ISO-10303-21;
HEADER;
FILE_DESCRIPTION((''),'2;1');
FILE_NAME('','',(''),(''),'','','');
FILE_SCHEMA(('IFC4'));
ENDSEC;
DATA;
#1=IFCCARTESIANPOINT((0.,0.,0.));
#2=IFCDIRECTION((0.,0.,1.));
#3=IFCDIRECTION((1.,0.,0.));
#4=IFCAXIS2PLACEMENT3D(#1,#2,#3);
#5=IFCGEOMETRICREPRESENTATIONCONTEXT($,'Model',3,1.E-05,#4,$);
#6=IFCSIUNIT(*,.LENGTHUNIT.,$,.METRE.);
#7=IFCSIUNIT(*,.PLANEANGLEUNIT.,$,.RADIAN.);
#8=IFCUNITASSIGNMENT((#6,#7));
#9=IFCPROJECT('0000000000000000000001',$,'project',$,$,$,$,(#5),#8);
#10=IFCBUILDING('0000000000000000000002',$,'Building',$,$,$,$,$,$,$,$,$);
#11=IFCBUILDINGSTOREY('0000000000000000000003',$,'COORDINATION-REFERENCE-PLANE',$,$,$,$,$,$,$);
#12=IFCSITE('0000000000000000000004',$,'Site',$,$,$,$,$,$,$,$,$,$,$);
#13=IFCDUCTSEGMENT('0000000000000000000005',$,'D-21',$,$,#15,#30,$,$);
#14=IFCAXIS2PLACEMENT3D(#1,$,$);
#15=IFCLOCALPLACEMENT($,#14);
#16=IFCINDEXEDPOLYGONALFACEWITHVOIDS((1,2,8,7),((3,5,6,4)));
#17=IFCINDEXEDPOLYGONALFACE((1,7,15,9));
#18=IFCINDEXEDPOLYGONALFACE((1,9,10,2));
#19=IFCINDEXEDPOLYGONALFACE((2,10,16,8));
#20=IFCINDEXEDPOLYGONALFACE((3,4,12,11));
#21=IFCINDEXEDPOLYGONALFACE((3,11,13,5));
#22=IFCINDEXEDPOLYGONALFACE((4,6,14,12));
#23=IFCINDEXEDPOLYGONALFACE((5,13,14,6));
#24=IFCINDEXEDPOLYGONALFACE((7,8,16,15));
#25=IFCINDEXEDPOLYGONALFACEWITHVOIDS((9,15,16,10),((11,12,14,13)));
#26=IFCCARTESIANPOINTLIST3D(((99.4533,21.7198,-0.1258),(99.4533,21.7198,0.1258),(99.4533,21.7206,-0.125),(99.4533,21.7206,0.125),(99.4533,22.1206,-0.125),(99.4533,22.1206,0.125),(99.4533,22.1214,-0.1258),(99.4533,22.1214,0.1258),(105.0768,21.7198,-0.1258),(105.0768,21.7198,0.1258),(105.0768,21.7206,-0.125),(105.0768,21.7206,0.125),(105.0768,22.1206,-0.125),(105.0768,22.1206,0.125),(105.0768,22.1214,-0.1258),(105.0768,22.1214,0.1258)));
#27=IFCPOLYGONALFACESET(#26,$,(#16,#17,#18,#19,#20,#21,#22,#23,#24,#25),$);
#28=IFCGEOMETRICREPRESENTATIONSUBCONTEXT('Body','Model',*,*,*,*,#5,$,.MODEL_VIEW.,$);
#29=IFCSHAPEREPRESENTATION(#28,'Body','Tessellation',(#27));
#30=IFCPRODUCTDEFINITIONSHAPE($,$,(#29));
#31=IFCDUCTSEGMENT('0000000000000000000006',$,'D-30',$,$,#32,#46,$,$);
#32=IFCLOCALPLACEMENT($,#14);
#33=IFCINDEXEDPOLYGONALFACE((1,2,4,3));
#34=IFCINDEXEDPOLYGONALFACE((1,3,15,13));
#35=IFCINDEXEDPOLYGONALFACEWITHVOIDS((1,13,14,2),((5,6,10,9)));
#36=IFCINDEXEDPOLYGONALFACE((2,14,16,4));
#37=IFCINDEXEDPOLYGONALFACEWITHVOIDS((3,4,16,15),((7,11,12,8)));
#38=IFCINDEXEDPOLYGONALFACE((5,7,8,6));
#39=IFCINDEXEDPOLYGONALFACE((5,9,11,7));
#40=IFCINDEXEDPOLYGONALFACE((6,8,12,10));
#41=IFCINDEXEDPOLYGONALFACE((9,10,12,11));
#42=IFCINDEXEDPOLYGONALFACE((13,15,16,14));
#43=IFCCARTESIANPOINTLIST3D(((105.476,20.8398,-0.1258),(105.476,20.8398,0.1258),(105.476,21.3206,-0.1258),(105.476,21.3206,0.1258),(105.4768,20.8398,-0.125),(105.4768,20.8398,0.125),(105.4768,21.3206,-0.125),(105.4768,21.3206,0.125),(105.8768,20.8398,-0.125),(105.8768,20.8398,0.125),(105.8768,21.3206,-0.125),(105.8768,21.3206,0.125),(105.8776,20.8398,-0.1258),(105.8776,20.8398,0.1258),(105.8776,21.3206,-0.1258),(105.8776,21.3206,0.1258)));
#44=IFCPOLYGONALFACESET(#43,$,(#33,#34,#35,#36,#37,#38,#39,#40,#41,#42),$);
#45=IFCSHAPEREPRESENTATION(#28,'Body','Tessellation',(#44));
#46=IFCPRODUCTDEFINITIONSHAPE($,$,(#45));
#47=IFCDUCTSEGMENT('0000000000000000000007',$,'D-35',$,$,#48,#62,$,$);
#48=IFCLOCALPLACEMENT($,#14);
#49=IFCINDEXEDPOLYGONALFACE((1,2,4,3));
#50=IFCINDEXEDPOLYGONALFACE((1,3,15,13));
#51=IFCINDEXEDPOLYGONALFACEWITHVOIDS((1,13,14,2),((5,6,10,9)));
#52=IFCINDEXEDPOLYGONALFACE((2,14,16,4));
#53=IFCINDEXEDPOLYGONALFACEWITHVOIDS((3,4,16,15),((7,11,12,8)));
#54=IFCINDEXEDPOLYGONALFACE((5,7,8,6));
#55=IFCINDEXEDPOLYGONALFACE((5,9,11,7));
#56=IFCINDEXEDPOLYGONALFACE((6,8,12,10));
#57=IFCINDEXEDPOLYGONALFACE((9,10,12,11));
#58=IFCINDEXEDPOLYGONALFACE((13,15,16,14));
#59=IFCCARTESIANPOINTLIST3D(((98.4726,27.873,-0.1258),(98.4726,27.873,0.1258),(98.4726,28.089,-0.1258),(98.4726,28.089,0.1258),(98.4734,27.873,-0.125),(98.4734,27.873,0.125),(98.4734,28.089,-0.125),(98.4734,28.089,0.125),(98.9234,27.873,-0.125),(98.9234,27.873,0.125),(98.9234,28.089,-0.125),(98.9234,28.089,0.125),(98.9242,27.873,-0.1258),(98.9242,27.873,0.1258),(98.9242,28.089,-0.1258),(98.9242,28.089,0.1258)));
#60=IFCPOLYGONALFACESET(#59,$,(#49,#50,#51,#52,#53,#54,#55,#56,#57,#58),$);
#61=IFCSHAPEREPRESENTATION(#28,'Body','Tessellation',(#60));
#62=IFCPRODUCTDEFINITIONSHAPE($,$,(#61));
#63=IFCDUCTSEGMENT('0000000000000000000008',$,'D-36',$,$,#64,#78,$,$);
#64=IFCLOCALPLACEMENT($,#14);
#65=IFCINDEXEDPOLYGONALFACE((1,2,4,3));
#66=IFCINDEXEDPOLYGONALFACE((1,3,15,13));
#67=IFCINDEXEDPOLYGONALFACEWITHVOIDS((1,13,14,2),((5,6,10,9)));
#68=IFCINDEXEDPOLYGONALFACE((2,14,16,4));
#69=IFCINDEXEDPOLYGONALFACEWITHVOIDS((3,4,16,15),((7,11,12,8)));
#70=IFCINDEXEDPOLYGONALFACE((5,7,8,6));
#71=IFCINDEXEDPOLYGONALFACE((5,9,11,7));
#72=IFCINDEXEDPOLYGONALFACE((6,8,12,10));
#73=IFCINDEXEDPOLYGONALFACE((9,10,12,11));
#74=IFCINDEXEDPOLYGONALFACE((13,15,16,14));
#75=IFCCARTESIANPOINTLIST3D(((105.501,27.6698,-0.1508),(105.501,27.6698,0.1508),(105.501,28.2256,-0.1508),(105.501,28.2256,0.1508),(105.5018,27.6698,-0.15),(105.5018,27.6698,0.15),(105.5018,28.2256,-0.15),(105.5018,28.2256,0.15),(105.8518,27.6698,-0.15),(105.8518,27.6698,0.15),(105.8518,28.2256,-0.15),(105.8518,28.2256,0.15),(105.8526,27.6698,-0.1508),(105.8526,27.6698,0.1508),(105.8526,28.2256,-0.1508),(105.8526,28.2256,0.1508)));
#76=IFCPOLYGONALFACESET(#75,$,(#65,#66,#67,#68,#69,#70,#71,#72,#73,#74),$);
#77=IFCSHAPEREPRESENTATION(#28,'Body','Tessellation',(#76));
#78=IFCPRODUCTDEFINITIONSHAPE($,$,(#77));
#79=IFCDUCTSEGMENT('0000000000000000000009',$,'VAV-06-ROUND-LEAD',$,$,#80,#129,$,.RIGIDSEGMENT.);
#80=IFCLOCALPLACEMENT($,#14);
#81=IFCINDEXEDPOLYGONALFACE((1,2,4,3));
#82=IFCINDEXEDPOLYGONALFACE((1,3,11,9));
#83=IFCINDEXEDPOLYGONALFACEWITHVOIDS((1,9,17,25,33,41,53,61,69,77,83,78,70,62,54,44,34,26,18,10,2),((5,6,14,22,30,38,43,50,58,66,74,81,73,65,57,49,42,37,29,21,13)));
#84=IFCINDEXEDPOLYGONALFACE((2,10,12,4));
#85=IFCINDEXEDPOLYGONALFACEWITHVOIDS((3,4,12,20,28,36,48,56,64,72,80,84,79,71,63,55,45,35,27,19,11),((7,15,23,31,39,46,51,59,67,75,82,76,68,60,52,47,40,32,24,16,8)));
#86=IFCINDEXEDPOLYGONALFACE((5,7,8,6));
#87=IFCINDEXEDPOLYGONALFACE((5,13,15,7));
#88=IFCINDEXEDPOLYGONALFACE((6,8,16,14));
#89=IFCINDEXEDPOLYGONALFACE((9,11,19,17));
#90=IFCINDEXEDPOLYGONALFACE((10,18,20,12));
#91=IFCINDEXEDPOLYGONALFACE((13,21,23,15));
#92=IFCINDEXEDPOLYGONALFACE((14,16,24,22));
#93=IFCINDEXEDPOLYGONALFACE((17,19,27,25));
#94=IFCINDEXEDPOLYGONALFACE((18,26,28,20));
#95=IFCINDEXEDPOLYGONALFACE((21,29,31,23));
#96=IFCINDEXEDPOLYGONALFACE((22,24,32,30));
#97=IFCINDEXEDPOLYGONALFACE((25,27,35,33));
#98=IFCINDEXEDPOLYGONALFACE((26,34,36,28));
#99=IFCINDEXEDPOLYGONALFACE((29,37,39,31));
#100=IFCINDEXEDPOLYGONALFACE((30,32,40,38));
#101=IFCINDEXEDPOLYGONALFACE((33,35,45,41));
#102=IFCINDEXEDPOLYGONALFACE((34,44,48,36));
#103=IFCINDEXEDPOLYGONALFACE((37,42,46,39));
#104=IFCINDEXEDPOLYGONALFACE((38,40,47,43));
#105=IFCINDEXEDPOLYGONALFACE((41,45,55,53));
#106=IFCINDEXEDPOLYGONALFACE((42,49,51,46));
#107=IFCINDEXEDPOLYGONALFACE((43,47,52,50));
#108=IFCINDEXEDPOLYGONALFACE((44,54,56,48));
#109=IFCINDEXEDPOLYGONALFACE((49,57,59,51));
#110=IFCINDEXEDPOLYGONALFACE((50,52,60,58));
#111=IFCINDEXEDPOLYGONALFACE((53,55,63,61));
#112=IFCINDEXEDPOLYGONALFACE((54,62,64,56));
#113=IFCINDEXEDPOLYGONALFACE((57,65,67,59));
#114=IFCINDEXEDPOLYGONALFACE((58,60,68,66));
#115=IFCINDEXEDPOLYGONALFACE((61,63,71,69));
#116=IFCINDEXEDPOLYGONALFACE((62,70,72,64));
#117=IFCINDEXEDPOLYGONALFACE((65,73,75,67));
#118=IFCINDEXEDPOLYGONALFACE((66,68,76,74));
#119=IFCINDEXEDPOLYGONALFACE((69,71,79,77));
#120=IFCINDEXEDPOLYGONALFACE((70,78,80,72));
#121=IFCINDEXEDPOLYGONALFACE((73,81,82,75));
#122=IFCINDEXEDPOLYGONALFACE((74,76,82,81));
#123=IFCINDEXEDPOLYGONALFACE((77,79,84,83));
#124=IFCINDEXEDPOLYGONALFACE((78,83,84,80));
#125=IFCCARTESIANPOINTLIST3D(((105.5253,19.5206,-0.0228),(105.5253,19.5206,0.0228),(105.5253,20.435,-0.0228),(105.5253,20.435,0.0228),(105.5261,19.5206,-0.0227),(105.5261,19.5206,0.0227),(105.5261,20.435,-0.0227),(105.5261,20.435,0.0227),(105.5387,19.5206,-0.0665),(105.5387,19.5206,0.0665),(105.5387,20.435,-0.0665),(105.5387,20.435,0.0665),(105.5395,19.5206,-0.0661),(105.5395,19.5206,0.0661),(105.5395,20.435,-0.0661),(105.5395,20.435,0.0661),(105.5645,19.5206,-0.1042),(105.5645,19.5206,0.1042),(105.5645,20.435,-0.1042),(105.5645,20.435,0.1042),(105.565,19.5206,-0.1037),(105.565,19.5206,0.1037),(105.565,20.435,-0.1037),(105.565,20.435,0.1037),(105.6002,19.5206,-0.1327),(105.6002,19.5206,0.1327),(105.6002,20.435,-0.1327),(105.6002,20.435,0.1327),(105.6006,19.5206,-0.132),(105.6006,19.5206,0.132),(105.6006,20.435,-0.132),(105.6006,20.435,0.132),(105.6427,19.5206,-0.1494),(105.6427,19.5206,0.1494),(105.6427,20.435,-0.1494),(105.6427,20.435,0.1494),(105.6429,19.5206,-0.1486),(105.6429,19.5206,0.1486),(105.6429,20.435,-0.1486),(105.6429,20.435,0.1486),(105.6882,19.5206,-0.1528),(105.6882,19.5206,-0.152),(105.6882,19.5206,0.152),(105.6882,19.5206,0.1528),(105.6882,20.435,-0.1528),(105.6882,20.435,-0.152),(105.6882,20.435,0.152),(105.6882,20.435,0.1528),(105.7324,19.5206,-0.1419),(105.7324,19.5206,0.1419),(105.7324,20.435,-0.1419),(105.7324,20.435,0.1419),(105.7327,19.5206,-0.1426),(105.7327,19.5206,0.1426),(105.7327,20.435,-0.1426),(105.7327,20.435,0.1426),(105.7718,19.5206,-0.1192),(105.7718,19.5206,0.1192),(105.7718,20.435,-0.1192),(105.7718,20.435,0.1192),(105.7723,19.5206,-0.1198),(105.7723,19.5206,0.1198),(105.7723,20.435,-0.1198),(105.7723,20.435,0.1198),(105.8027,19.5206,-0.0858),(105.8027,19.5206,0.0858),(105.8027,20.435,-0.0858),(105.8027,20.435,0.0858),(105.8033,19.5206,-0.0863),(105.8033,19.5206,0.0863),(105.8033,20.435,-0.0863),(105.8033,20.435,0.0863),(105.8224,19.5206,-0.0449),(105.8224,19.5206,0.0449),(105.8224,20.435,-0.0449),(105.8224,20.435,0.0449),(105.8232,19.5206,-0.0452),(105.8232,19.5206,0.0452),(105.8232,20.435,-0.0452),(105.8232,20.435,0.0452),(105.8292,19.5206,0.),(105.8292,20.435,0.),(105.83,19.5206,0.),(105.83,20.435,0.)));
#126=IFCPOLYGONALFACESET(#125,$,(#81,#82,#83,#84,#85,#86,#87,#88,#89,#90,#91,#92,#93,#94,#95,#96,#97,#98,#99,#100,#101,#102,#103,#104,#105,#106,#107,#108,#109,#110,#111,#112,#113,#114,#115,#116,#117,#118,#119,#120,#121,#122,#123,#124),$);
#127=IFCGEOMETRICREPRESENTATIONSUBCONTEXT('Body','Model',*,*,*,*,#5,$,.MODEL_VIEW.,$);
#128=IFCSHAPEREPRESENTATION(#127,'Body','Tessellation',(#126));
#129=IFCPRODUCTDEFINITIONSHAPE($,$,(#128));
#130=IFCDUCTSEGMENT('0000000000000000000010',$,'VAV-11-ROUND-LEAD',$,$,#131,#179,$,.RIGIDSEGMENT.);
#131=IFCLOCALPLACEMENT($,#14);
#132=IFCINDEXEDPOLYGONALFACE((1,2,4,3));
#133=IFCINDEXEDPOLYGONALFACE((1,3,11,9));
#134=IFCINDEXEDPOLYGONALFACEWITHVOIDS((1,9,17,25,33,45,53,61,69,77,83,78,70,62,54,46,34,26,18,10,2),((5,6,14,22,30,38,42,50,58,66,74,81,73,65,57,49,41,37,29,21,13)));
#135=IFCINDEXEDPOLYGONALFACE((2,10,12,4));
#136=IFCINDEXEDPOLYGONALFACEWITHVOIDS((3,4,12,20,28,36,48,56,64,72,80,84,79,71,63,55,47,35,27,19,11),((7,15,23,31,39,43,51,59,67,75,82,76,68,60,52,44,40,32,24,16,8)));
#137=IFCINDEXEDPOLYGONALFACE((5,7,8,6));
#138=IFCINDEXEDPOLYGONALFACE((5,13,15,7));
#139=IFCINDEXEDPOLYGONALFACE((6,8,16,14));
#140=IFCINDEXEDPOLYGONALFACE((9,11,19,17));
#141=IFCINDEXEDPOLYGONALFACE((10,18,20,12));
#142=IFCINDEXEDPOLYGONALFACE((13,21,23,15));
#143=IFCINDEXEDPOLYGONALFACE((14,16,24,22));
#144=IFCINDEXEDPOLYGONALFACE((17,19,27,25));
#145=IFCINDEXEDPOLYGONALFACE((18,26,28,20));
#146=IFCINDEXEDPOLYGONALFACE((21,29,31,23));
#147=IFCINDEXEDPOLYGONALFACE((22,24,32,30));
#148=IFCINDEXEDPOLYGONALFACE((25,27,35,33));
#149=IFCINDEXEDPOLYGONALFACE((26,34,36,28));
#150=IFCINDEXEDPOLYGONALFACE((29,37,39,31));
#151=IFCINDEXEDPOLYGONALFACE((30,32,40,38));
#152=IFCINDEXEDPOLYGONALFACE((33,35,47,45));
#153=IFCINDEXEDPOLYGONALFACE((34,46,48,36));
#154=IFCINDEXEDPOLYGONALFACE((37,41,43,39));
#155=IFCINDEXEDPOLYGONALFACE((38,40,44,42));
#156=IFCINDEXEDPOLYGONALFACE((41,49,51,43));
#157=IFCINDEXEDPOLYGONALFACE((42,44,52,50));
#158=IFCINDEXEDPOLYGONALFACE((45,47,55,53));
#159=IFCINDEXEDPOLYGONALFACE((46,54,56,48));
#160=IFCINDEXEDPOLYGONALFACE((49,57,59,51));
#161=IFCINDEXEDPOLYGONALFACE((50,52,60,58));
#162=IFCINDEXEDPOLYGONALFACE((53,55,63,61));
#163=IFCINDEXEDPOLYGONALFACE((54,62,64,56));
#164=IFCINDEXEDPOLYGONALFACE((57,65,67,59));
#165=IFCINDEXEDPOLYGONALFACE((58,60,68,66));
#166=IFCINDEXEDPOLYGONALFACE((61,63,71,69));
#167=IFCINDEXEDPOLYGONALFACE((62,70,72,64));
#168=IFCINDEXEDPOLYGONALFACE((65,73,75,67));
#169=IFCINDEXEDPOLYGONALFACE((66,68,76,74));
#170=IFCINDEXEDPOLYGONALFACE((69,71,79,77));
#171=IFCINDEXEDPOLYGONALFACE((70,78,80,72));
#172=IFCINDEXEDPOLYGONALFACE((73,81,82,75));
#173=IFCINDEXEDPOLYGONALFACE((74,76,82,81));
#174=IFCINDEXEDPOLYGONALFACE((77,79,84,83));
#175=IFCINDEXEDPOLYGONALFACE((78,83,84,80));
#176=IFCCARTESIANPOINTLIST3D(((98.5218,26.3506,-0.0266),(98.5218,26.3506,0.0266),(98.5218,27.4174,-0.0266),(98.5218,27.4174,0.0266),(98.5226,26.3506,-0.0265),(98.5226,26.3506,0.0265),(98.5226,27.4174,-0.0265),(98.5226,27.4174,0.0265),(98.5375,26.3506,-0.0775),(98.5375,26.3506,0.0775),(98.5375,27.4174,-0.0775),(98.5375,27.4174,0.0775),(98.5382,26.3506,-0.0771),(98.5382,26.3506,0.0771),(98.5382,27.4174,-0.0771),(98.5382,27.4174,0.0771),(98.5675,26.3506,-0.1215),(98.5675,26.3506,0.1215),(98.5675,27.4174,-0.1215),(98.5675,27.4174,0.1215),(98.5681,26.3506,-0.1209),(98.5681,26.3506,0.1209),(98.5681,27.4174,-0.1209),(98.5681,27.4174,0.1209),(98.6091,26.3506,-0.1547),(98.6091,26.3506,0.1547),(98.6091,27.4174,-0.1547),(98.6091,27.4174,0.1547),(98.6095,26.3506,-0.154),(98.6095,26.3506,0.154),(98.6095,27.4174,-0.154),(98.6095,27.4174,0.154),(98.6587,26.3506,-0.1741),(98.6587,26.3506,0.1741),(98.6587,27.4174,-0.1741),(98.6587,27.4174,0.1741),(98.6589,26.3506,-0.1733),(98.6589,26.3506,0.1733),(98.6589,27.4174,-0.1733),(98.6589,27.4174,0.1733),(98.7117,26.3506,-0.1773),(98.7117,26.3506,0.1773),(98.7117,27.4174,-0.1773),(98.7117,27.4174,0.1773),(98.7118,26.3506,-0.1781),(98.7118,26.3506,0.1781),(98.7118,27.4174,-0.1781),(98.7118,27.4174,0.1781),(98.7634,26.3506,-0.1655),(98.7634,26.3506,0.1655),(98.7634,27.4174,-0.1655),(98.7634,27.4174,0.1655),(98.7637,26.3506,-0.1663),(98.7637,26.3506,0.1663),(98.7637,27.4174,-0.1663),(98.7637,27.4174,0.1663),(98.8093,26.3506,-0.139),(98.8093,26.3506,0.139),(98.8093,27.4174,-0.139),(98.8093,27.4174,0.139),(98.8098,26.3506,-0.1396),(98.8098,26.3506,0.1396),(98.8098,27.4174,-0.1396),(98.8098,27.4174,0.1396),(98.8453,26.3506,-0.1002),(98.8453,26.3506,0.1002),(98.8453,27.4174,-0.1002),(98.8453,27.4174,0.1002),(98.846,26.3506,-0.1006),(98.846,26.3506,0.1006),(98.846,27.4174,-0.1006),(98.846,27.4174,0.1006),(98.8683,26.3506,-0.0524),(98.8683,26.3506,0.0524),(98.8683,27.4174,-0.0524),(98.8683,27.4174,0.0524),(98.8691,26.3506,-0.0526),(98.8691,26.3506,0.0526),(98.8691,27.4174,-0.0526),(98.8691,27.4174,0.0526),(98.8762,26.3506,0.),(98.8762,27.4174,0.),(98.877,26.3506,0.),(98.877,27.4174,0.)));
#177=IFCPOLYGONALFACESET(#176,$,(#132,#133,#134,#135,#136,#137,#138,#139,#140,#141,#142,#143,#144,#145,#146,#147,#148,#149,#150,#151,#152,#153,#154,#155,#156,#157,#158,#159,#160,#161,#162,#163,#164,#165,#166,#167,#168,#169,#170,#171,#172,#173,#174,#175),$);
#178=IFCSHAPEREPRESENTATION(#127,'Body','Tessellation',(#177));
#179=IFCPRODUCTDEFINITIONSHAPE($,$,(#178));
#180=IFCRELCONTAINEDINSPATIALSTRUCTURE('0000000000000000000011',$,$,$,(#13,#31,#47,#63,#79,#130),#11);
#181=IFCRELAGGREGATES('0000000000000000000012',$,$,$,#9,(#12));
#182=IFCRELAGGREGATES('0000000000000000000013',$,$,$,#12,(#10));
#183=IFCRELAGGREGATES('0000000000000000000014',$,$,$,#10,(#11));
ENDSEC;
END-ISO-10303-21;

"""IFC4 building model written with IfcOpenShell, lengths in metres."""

from ifc_helpers import new_model, si_unit, frame, origin, origin_with_axes, place, context, subcontext, project, spatial, hollow_rectangle, hollow_circle, extrude, element, save


model = new_model("IFC4")

# Units and contexts
model_context = context("Model", 3, precision=1e-05, world=origin_with_axes())
body_context_1 = subcontext(model_context, "Body", "Model", "MODEL_VIEW")
body_context_2 = subcontext(model_context, "Body", "Model", "MODEL_VIEW")
ifc_project = project(units=[si_unit("LENGTHUNIT", "METRE"), si_unit("PLANEANGLEUNIT", "RADIAN")], contexts=[model_context])

# Site, building, storey
site = spatial("IfcSite", under=ifc_project, Name="Site")
building = spatial("IfcBuilding", under=site, Name="Building")
storey = spatial("IfcBuildingStorey", under=building, Name="COORDINATION-REFERENCE-PLANE")

# Duct segments
duct_segment_1_placement = place(None, frame((99.4533, 21.9206, 0.0), z_axis=(1.0, 0.0, 0.0), x_axis=(0.0, 1.0, 0.0)))
element("IfcDuctSegment", 1, at=duct_segment_1_placement, inside=storey, Name="D-21", context=body_context_1, shape_type="SweptSolid", body=[
    extrude(hollow_rectangle(XDim=0.4016, YDim=0.2516, WallThickness=0.0008), origin(), (0.0, 0.0, 1.0), 5.6234),
])
duct_segment_2_placement = place(None, frame((105.6768, 20.8398, 0.0), z_axis=(0.0, 1.0, 0.0), x_axis=(1.0, 0.0, 0.0)))
element("IfcDuctSegment", 2, at=duct_segment_2_placement, inside=storey, Name="D-30", context=body_context_1, shape_type="SweptSolid", body=[
    extrude(hollow_rectangle(XDim=0.4016, YDim=0.2516, WallThickness=0.0008), origin(), (0.0, 0.0, 1.0), 0.4808),
])
duct_segment_3_placement = place(None, frame((98.6984, 27.873, 0.0), z_axis=(0.0, 1.0, 0.0), x_axis=(1.0, 0.0, 0.0)))
element("IfcDuctSegment", 3, at=duct_segment_3_placement, inside=storey, Name="D-35", context=body_context_1, shape_type="SweptSolid", body=[
    extrude(hollow_rectangle(XDim=0.4516, YDim=0.2516, WallThickness=0.0008), origin(), (0.0, 0.0, 1.0), 0.216),
])
duct_segment_4_placement = place(None, frame((105.6768, 27.6698, 0.0), z_axis=(0.0, 1.0, 0.0), x_axis=(1.0, 0.0, 0.0)))
element("IfcDuctSegment", 4, at=duct_segment_4_placement, inside=storey, Name="D-36", context=body_context_1, shape_type="SweptSolid", body=[
    extrude(hollow_rectangle(XDim=0.3516, YDim=0.3016, WallThickness=0.0008), origin(), (0.0, 0.0, 1.0), 0.5558),
])

# Duct segments
duct_segment_5_placement = place(None, frame((105.6768, 20.435, 0.0), z_axis=(0.0, -1.0, 0.0), x_axis=(1.0, 0.0, 0.0)))
element("IfcDuctSegment", 5, at=duct_segment_5_placement, inside=storey, Name="VAV-06-ROUND-LEAD", PredefinedType="RIGIDSEGMENT", context=body_context_2, shape_type="SweptSolid", body=[
    extrude(hollow_circle(Radius=0.1532, WallThickness=0.0008), origin(), (0.0, 0.0, 1.0), 0.9144),
])
duct_segment_6_placement = place(None, frame((98.6984, 27.4174, 0.0), z_axis=(0.0, -1.0, 0.0), x_axis=(1.0, 0.0, 0.0)))
element("IfcDuctSegment", 6, at=duct_segment_6_placement, inside=storey, Name="VAV-11-ROUND-LEAD", PredefinedType="RIGIDSEGMENT", context=body_context_2, shape_type="SweptSolid", body=[
    extrude(hollow_circle(Radius=0.1786, WallThickness=0.0008), origin(), (0.0, 0.0, 1.0), 1.0668),
])

save(model, "model.ifc")
